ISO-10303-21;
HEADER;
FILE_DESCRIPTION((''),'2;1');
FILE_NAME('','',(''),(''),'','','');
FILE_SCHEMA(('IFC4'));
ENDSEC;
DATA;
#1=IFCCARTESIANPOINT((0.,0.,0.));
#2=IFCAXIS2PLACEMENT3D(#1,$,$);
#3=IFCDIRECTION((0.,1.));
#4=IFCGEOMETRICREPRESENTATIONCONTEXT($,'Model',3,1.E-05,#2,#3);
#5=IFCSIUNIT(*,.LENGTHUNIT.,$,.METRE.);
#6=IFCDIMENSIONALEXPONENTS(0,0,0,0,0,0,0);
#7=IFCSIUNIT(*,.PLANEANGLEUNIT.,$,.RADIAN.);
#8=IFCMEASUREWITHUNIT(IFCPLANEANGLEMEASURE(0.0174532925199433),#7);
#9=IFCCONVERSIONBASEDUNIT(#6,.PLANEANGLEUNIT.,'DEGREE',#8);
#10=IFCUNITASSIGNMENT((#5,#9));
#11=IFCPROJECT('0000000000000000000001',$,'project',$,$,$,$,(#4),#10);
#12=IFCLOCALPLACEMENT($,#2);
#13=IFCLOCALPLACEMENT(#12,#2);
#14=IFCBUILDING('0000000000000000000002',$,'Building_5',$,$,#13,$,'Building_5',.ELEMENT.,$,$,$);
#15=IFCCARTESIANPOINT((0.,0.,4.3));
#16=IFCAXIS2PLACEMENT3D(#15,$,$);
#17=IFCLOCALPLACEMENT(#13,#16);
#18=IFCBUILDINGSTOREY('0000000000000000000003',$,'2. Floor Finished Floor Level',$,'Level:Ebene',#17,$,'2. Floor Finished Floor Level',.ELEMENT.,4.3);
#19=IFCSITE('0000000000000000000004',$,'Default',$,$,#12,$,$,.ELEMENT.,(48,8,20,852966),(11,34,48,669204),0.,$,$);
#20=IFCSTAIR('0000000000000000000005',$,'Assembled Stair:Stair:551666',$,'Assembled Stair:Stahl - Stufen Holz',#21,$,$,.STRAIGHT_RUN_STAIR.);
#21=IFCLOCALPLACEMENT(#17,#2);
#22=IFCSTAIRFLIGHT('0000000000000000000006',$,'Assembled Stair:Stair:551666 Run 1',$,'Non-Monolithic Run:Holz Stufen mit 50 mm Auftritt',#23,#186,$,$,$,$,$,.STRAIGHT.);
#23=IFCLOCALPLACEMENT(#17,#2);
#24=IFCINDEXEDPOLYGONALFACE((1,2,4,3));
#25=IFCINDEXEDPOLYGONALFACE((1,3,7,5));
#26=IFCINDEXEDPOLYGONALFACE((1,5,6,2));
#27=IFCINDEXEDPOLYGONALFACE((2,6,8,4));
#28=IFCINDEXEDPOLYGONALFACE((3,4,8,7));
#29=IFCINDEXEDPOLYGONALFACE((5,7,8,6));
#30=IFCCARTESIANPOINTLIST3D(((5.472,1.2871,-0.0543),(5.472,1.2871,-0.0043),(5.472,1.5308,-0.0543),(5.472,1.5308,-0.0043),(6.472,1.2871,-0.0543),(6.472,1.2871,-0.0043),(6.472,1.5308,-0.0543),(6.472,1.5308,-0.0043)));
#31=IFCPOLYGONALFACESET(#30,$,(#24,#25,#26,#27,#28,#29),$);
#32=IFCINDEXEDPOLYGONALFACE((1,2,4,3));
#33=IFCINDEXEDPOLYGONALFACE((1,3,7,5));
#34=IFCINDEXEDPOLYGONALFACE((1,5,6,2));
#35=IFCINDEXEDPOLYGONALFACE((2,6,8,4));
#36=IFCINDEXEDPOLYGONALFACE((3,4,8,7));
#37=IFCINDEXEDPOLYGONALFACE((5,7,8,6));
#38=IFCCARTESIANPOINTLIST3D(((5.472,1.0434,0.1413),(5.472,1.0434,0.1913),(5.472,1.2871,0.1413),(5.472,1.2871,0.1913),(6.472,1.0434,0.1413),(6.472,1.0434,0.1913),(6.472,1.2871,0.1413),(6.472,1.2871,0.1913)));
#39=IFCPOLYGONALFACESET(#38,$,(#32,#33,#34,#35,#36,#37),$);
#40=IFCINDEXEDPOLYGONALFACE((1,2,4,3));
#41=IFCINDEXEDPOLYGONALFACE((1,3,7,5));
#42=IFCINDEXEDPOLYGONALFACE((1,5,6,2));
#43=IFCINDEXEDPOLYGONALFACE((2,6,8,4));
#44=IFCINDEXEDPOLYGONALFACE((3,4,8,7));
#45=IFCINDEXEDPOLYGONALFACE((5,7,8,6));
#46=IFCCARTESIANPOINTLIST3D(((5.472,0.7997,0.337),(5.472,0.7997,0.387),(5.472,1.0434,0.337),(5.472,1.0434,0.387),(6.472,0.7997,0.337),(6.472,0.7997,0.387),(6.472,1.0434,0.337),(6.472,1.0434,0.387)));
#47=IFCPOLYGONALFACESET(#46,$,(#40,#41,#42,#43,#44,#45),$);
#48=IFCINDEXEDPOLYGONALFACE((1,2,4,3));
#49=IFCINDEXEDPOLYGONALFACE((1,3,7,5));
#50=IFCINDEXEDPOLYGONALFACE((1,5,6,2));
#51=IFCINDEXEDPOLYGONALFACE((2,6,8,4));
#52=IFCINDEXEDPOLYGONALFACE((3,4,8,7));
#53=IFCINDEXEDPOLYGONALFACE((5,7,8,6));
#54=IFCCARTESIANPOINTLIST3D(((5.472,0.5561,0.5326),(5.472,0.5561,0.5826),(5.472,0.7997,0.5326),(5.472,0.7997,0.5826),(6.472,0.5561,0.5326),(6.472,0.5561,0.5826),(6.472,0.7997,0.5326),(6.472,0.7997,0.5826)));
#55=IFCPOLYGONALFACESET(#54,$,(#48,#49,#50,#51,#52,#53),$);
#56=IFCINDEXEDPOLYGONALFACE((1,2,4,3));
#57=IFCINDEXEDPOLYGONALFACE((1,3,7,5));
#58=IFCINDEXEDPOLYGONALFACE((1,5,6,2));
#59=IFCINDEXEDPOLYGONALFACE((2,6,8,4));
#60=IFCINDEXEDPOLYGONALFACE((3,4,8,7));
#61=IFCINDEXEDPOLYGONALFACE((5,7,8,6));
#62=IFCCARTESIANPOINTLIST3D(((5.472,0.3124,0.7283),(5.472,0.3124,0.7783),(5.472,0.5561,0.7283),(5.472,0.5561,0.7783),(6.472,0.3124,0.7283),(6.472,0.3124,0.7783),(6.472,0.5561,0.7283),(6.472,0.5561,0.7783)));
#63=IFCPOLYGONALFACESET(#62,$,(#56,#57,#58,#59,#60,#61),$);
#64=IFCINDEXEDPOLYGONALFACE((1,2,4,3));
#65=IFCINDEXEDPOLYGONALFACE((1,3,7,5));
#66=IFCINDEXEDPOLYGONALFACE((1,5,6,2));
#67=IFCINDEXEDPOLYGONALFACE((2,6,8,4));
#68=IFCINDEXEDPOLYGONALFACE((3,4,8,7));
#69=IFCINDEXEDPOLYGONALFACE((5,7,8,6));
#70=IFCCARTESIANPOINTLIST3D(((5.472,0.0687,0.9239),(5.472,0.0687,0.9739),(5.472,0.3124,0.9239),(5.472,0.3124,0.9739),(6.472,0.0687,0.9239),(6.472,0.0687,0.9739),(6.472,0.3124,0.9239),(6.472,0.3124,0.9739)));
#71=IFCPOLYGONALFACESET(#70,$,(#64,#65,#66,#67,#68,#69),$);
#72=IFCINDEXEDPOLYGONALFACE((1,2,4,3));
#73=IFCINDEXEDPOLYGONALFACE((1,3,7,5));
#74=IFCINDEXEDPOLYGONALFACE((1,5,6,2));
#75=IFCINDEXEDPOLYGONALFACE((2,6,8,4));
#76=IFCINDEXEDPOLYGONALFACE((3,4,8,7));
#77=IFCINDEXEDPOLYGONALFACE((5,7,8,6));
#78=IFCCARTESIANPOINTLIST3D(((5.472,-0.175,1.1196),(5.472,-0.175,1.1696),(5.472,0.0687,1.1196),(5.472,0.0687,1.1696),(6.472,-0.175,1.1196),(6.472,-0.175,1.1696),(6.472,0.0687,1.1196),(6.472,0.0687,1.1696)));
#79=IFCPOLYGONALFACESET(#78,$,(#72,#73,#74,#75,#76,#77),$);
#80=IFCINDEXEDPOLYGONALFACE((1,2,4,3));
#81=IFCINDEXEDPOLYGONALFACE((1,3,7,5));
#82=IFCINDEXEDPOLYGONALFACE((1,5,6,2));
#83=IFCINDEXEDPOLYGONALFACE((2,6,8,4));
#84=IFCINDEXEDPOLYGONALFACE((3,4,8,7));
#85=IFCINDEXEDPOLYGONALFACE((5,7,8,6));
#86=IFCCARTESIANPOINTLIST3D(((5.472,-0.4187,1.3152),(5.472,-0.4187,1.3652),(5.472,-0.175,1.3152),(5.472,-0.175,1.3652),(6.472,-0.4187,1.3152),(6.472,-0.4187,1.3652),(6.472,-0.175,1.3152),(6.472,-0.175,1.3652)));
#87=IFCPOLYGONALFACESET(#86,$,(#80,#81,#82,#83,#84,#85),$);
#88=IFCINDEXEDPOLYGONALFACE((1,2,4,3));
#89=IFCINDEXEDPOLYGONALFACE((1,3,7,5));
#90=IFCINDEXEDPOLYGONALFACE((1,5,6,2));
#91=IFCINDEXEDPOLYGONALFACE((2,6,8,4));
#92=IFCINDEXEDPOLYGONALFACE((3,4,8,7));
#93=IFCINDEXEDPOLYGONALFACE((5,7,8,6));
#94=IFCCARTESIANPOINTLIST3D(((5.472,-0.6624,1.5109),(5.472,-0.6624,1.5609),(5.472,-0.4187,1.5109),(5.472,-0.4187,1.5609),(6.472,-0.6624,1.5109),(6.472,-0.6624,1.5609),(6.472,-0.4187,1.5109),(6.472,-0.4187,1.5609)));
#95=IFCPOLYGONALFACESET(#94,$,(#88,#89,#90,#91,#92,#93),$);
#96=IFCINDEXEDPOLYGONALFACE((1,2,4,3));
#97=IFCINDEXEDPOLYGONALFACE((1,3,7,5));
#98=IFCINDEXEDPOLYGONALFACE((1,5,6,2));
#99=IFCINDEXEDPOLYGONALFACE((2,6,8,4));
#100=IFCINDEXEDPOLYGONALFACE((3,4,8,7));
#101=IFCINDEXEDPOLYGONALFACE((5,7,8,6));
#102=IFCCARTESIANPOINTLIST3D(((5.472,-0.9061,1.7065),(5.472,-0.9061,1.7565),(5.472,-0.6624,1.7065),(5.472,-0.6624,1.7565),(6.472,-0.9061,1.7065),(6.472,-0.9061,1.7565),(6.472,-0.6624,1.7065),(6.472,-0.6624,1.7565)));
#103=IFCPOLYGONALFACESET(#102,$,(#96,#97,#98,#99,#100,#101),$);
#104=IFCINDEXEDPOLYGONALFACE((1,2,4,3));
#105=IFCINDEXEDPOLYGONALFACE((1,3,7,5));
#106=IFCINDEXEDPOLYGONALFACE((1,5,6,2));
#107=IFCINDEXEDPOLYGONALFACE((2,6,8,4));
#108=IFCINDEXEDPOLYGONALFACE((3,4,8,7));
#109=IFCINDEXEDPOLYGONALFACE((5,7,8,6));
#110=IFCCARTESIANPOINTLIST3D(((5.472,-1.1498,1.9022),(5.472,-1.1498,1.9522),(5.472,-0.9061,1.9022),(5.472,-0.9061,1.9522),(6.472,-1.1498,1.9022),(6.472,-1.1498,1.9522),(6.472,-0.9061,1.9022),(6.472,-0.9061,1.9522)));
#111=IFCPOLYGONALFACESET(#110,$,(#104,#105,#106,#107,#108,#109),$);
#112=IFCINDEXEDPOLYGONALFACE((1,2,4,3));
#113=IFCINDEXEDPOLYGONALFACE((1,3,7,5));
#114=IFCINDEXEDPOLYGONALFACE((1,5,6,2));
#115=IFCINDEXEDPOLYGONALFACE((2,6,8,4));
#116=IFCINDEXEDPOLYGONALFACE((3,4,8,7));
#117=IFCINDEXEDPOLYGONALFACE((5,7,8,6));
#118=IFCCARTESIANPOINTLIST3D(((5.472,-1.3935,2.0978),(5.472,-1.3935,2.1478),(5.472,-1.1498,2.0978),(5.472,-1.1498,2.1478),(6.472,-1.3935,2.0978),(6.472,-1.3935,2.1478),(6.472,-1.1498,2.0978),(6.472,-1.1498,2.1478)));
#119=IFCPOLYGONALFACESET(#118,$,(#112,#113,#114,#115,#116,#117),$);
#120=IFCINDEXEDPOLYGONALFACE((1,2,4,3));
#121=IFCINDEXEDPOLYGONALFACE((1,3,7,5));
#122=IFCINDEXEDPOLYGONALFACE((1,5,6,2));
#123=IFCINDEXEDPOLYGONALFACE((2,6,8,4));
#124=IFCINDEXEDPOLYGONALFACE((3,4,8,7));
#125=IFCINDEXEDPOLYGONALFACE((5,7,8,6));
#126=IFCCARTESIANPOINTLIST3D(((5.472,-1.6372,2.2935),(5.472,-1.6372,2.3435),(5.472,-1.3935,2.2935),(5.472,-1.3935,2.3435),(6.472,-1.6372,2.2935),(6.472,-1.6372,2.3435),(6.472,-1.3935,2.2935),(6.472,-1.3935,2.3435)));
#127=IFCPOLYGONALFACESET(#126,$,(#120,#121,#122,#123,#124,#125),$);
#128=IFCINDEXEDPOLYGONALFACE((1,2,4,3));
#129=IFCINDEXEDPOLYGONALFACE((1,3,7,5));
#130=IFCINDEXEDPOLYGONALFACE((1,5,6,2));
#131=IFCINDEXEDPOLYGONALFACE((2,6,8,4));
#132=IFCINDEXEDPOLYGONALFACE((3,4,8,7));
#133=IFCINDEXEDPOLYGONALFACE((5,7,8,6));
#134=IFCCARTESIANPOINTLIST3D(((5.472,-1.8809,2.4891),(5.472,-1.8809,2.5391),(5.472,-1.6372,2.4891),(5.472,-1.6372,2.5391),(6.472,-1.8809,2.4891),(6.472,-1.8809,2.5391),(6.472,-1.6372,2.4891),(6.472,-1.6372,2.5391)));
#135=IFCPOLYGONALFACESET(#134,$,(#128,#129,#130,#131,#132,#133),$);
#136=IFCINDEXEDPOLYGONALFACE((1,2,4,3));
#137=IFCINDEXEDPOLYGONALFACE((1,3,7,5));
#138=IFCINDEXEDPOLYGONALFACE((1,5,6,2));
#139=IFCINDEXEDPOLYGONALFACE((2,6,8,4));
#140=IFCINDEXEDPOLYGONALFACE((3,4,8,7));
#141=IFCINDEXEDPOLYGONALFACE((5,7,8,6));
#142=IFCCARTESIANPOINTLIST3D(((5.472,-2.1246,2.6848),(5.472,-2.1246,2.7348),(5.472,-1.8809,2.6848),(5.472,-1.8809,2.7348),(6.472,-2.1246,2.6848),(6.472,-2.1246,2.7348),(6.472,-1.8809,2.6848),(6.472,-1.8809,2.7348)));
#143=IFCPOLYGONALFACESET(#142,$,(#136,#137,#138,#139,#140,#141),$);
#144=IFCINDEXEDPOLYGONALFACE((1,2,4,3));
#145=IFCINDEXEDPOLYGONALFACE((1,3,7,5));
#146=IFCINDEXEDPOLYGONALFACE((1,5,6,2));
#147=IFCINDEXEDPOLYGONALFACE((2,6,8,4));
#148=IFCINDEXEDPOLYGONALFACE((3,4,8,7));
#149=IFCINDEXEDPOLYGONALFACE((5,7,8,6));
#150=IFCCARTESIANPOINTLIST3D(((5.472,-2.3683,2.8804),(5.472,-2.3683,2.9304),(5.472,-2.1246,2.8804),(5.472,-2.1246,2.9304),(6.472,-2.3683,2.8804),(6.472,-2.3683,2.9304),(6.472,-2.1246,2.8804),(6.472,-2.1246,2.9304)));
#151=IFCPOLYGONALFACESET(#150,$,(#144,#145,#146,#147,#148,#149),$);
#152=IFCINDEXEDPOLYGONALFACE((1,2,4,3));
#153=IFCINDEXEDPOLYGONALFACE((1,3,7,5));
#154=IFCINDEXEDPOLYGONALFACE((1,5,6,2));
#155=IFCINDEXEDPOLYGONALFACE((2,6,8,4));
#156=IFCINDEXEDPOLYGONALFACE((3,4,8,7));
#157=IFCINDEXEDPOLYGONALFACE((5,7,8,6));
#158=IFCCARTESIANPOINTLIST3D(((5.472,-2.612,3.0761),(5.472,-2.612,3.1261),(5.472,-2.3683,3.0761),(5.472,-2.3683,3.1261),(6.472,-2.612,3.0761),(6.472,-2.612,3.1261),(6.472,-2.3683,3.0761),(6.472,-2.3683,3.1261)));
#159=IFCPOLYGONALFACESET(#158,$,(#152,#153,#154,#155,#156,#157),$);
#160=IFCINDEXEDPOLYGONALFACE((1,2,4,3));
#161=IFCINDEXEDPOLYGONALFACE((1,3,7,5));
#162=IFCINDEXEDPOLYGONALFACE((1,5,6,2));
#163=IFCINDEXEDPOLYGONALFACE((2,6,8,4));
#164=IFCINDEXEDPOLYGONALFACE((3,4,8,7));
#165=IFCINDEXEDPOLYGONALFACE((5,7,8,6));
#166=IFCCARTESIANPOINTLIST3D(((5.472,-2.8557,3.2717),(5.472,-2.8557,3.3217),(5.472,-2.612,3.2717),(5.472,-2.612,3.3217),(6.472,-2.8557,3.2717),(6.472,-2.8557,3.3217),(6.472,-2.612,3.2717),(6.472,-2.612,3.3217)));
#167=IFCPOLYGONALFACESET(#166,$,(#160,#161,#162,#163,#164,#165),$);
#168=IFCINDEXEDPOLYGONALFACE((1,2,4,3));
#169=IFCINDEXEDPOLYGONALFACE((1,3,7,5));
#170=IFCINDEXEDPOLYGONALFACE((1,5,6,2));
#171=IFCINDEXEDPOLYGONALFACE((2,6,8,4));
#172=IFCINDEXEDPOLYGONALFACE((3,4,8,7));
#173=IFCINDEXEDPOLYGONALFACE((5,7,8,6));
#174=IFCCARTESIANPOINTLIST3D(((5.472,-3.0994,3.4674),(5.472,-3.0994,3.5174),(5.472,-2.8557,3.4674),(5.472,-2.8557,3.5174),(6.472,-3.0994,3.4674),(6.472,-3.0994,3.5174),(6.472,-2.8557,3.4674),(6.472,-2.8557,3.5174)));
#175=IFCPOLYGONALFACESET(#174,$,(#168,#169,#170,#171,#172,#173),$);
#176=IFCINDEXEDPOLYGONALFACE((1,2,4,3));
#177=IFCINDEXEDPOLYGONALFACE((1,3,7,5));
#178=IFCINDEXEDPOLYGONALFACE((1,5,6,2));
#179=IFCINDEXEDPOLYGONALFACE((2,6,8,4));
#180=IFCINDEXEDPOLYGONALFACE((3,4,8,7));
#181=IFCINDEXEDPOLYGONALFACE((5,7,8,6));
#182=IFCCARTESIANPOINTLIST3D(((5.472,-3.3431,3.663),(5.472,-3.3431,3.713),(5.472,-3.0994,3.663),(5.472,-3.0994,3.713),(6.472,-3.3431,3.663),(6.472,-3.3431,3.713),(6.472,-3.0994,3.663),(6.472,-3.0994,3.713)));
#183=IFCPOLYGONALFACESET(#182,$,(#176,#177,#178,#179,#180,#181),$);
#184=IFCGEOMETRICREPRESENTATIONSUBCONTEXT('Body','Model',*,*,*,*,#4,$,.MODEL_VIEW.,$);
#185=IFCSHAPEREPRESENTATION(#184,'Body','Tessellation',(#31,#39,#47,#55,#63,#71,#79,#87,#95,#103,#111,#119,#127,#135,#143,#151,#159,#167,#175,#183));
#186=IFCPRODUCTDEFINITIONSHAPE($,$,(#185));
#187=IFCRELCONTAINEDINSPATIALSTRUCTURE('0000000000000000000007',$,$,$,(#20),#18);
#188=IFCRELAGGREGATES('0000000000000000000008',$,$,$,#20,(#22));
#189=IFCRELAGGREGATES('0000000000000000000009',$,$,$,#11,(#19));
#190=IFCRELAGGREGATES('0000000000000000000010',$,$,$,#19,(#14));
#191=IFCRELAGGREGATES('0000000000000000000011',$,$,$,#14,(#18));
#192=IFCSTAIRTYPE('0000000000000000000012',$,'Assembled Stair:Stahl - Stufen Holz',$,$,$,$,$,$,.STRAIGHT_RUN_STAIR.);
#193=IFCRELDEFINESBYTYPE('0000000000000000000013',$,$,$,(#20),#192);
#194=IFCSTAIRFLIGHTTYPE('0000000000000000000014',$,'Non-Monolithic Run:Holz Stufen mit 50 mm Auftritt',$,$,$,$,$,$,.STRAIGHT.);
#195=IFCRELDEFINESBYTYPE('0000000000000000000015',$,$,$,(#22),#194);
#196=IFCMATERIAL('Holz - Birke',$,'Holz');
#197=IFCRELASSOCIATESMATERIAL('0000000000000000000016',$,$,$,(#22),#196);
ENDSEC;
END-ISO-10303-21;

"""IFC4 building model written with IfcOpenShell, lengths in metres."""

from ifc_helpers import new_model, entity, si_unit, converted_unit, direction, frame, origin, place, context, subcontext, project, spatial, indexed_curve, outline, extrude, material, type_object, element, aggregate, save


model = new_model("IFC4")

# Units and contexts
model_context = context("Model", 3, precision=1e-05, world=origin(), true_north=direction((0.0, 1.0)))
body_context = subcontext(model_context, "Body", "Model", "MODEL_VIEW")
ifc_project = project(units=[si_unit("LENGTHUNIT", "METRE"), converted_unit("PLANEANGLEUNIT", "DEGREE", entity("IfcPlaneAngleMeasure", 0.0174532925199433), si_unit("PLANEANGLEUNIT", "RADIAN"), dimensions=[0, 0, 0, 0, 0, 0, 0])], contexts=[model_context])

# Site, building, storey
site_placement = place(None, origin())
site = spatial("IfcSite", under=ifc_project, at=site_placement, Name="Default", CompositionType="ELEMENT", RefLatitude=(48, 8, 20, 852966), RefLongitude=(11, 34, 48, 669204), RefElevation=0.0)
building_placement = place(site_placement, origin())
building = spatial("IfcBuilding", under=site, at=building_placement, Name="Building_5", LongName="Building_5", CompositionType="ELEMENT")
storey_placement = place(building_placement, frame((0.0, 0.0, 4.3)))
storey = spatial("IfcBuildingStorey", under=building, at=storey_placement, Name="2. Floor Finished Floor Level", ObjectType="Level:Ebene", LongName="2. Floor Finished Floor Level", CompositionType="ELEMENT", Elevation=4.3)

# Stair
stair_type_1 = type_object("IfcStairType", Name="Assembled Stair:Stahl - Stufen Holz", PredefinedType="STRAIGHT_RUN_STAIR")
stair_1_placement = place(storey_placement, origin())
stair_1 = element("IfcStair", 1, at=stair_1_placement, inside=storey, type_object=stair_type_1, Name="Assembled Stair:Stair:551666", ObjectType="Assembled Stair:Stahl - Stufen Holz", PredefinedType="STRAIGHT_RUN_STAIR")

# Stair flight
ifc_material_1 = material(Name="Holz - Birke", Category="Holz")
stair_flight_type_1 = type_object("IfcStairFlightType", Name="Non-Monolithic Run:Holz Stufen mit 50 mm Auftritt", PredefinedType="STRAIGHT")
stair_flight_1_placement = place(stair_1_placement, origin())
stair_flight_1 = element("IfcStairFlight", 2, at=stair_flight_1_placement, type_object=stair_flight_type_1, material=ifc_material_1, Name="Assembled Stair:Stair:551666 Run 1", ObjectType="Non-Monolithic Run:Holz Stufen mit 50 mm Auftritt", PredefinedType="STRAIGHT", context=body_context, shape_type="SweptSolid", body=[
    extrude(outline(indexed_curve([(-0.1218, -0.5), (0.1218, -0.5), (0.1218, 0.5), (-0.1218, 0.5), (-0.1218, -0.5)], self_intersect=False)), frame((5.972, 1.409, -0.0543), z_axis=(0.0, 0.0, 1.0), x_axis=(0.0, 1.0, 0.0)), (0.0, 0.0, 1.0), 0.05),
    extrude(outline(indexed_curve([(-0.1218, -0.5), (0.1218, -0.5), (0.1218, 0.5), (-0.1218, 0.5), (-0.1218, -0.5)], self_intersect=False)), frame((5.972, 1.1653, 0.1413), z_axis=(0.0, 0.0, 1.0), x_axis=(0.0, 1.0, 0.0)), (0.0, 0.0, 1.0), 0.05),
    extrude(outline(indexed_curve([(-0.1218, -0.5), (0.1218, -0.5), (0.1218, 0.5), (-0.1218, 0.5), (-0.1218, -0.5)], self_intersect=False)), frame((5.972, 0.9216, 0.337), z_axis=(0.0, 0.0, 1.0), x_axis=(0.0, 1.0, 0.0)), (0.0, 0.0, 1.0), 0.05),
    extrude(outline(indexed_curve([(-0.1218, -0.5), (0.1218, -0.5), (0.1218, 0.5), (-0.1218, 0.5), (-0.1218, -0.5)], self_intersect=False)), frame((5.972, 0.6779, 0.5326), z_axis=(0.0, 0.0, 1.0), x_axis=(0.0, 1.0, 0.0)), (0.0, 0.0, 1.0), 0.05),
    extrude(outline(indexed_curve([(-0.1218, -0.5), (0.1218, -0.5), (0.1218, 0.5), (-0.1218, 0.5), (-0.1218, -0.5)], self_intersect=False)), frame((5.972, 0.4342, 0.7283), z_axis=(0.0, 0.0, 1.0), x_axis=(0.0, 1.0, 0.0)), (0.0, 0.0, 1.0), 0.05),
    extrude(outline(indexed_curve([(-0.1218, -0.5), (0.1218, -0.5), (0.1218, 0.5), (-0.1218, 0.5), (-0.1218, -0.5)], self_intersect=False)), frame((5.972, 0.1905, 0.9239), z_axis=(0.0, 0.0, 1.0), x_axis=(0.0, 1.0, 0.0)), (0.0, 0.0, 1.0), 0.05),
    extrude(outline(indexed_curve([(-0.1218, -0.5), (0.1218, -0.5), (0.1218, 0.5), (-0.1218, 0.5), (-0.1218, -0.5)], self_intersect=False)), frame((5.972, -0.0532, 1.1196), z_axis=(0.0, 0.0, 1.0), x_axis=(0.0, 1.0, 0.0)), (0.0, 0.0, 1.0), 0.05),
    extrude(outline(indexed_curve([(-0.1218, -0.5), (0.1218, -0.5), (0.1218, 0.5), (-0.1218, 0.5), (-0.1218, -0.5)], self_intersect=False)), frame((5.972, -0.2969, 1.3152), z_axis=(0.0, 0.0, 1.0), x_axis=(0.0, 1.0, 0.0)), (0.0, 0.0, 1.0), 0.05),
    extrude(outline(indexed_curve([(-0.1218, -0.5), (0.1218, -0.5), (0.1218, 0.5), (-0.1218, 0.5), (-0.1218, -0.5)], self_intersect=False)), frame((5.972, -0.5406, 1.5109), z_axis=(0.0, 0.0, 1.0), x_axis=(0.0, 1.0, 0.0)), (0.0, 0.0, 1.0), 0.05),
    extrude(outline(indexed_curve([(-0.1218, -0.5), (0.1218, -0.5), (0.1218, 0.5), (-0.1218, 0.5), (-0.1218, -0.5)], self_intersect=False)), frame((5.972, -0.7843, 1.7065), z_axis=(0.0, 0.0, 1.0), x_axis=(0.0, 1.0, 0.0)), (0.0, 0.0, 1.0), 0.05),
    extrude(outline(indexed_curve([(-0.1218, -0.5), (0.1218, -0.5), (0.1218, 0.5), (-0.1218, 0.5), (-0.1218, -0.5)], self_intersect=False)), frame((5.972, -1.028, 1.9022), z_axis=(0.0, 0.0, 1.0), x_axis=(0.0, 1.0, 0.0)), (0.0, 0.0, 1.0), 0.05),
    extrude(outline(indexed_curve([(-0.1218, -0.5), (0.1218, -0.5), (0.1218, 0.5), (-0.1218, 0.5), (-0.1218, -0.5)], self_intersect=False)), frame((5.972, -1.2717, 2.0978), z_axis=(0.0, 0.0, 1.0), x_axis=(0.0, 1.0, 0.0)), (0.0, 0.0, 1.0), 0.05),
    extrude(outline(indexed_curve([(-0.1218, -0.5), (0.1218, -0.5), (0.1218, 0.5), (-0.1218, 0.5), (-0.1218, -0.5)], self_intersect=False)), frame((5.972, -1.5154, 2.2935), z_axis=(0.0, 0.0, 1.0), x_axis=(0.0, 1.0, 0.0)), (0.0, 0.0, 1.0), 0.05),
    extrude(outline(indexed_curve([(-0.1218, -0.5), (0.1218, -0.5), (0.1218, 0.5), (-0.1218, 0.5), (-0.1218, -0.5)], self_intersect=False)), frame((5.972, -1.7591, 2.4891), z_axis=(0.0, 0.0, 1.0), x_axis=(0.0, 1.0, 0.0)), (0.0, 0.0, 1.0), 0.05),
    extrude(outline(indexed_curve([(-0.1218, -0.5), (0.1218, -0.5), (0.1218, 0.5), (-0.1218, 0.5), (-0.1218, -0.5)], self_intersect=False)), frame((5.972, -2.0028, 2.6848), z_axis=(0.0, 0.0, 1.0), x_axis=(0.0, 1.0, 0.0)), (0.0, 0.0, 1.0), 0.05),
    extrude(outline(indexed_curve([(-0.1218, -0.5), (0.1218, -0.5), (0.1218, 0.5), (-0.1218, 0.5), (-0.1218, -0.5)], self_intersect=False)), frame((5.972, -2.2464, 2.8804), z_axis=(0.0, 0.0, 1.0), x_axis=(0.0, 1.0, 0.0)), (0.0, 0.0, 1.0), 0.05),
    extrude(outline(indexed_curve([(-0.1218, -0.5), (0.1218, -0.5), (0.1218, 0.5), (-0.1218, 0.5), (-0.1218, -0.5)], self_intersect=False)), frame((5.972, -2.4901, 3.0761), z_axis=(0.0, 0.0, 1.0), x_axis=(0.0, 1.0, 0.0)), (0.0, 0.0, 1.0), 0.05),
    extrude(outline(indexed_curve([(-0.1218, -0.5), (0.1218, -0.5), (0.1218, 0.5), (-0.1218, 0.5), (-0.1218, -0.5)], self_intersect=False)), frame((5.972, -2.7338, 3.2717), z_axis=(0.0, 0.0, 1.0), x_axis=(0.0, 1.0, 0.0)), (0.0, 0.0, 1.0), 0.05),
    extrude(outline(indexed_curve([(-0.1218, -0.5), (0.1218, -0.5), (0.1218, 0.5), (-0.1218, 0.5), (-0.1218, -0.5)], self_intersect=False)), frame((5.972, -2.9775, 3.4674), z_axis=(0.0, 0.0, 1.0), x_axis=(0.0, 1.0, 0.0)), (0.0, 0.0, 1.0), 0.05),
    extrude(outline(indexed_curve([(-0.1218, -0.5), (0.1218, -0.5), (0.1218, 0.5), (-0.1218, 0.5), (-0.1218, -0.5)], self_intersect=False)), frame((5.972, -3.2212, 3.663), z_axis=(0.0, 0.0, 1.0), x_axis=(0.0, 1.0, 0.0)), (0.0, 0.0, 1.0), 0.05),
])
aggregate(stair_1, [stair_flight_1])

save(model, "model.ifc")
